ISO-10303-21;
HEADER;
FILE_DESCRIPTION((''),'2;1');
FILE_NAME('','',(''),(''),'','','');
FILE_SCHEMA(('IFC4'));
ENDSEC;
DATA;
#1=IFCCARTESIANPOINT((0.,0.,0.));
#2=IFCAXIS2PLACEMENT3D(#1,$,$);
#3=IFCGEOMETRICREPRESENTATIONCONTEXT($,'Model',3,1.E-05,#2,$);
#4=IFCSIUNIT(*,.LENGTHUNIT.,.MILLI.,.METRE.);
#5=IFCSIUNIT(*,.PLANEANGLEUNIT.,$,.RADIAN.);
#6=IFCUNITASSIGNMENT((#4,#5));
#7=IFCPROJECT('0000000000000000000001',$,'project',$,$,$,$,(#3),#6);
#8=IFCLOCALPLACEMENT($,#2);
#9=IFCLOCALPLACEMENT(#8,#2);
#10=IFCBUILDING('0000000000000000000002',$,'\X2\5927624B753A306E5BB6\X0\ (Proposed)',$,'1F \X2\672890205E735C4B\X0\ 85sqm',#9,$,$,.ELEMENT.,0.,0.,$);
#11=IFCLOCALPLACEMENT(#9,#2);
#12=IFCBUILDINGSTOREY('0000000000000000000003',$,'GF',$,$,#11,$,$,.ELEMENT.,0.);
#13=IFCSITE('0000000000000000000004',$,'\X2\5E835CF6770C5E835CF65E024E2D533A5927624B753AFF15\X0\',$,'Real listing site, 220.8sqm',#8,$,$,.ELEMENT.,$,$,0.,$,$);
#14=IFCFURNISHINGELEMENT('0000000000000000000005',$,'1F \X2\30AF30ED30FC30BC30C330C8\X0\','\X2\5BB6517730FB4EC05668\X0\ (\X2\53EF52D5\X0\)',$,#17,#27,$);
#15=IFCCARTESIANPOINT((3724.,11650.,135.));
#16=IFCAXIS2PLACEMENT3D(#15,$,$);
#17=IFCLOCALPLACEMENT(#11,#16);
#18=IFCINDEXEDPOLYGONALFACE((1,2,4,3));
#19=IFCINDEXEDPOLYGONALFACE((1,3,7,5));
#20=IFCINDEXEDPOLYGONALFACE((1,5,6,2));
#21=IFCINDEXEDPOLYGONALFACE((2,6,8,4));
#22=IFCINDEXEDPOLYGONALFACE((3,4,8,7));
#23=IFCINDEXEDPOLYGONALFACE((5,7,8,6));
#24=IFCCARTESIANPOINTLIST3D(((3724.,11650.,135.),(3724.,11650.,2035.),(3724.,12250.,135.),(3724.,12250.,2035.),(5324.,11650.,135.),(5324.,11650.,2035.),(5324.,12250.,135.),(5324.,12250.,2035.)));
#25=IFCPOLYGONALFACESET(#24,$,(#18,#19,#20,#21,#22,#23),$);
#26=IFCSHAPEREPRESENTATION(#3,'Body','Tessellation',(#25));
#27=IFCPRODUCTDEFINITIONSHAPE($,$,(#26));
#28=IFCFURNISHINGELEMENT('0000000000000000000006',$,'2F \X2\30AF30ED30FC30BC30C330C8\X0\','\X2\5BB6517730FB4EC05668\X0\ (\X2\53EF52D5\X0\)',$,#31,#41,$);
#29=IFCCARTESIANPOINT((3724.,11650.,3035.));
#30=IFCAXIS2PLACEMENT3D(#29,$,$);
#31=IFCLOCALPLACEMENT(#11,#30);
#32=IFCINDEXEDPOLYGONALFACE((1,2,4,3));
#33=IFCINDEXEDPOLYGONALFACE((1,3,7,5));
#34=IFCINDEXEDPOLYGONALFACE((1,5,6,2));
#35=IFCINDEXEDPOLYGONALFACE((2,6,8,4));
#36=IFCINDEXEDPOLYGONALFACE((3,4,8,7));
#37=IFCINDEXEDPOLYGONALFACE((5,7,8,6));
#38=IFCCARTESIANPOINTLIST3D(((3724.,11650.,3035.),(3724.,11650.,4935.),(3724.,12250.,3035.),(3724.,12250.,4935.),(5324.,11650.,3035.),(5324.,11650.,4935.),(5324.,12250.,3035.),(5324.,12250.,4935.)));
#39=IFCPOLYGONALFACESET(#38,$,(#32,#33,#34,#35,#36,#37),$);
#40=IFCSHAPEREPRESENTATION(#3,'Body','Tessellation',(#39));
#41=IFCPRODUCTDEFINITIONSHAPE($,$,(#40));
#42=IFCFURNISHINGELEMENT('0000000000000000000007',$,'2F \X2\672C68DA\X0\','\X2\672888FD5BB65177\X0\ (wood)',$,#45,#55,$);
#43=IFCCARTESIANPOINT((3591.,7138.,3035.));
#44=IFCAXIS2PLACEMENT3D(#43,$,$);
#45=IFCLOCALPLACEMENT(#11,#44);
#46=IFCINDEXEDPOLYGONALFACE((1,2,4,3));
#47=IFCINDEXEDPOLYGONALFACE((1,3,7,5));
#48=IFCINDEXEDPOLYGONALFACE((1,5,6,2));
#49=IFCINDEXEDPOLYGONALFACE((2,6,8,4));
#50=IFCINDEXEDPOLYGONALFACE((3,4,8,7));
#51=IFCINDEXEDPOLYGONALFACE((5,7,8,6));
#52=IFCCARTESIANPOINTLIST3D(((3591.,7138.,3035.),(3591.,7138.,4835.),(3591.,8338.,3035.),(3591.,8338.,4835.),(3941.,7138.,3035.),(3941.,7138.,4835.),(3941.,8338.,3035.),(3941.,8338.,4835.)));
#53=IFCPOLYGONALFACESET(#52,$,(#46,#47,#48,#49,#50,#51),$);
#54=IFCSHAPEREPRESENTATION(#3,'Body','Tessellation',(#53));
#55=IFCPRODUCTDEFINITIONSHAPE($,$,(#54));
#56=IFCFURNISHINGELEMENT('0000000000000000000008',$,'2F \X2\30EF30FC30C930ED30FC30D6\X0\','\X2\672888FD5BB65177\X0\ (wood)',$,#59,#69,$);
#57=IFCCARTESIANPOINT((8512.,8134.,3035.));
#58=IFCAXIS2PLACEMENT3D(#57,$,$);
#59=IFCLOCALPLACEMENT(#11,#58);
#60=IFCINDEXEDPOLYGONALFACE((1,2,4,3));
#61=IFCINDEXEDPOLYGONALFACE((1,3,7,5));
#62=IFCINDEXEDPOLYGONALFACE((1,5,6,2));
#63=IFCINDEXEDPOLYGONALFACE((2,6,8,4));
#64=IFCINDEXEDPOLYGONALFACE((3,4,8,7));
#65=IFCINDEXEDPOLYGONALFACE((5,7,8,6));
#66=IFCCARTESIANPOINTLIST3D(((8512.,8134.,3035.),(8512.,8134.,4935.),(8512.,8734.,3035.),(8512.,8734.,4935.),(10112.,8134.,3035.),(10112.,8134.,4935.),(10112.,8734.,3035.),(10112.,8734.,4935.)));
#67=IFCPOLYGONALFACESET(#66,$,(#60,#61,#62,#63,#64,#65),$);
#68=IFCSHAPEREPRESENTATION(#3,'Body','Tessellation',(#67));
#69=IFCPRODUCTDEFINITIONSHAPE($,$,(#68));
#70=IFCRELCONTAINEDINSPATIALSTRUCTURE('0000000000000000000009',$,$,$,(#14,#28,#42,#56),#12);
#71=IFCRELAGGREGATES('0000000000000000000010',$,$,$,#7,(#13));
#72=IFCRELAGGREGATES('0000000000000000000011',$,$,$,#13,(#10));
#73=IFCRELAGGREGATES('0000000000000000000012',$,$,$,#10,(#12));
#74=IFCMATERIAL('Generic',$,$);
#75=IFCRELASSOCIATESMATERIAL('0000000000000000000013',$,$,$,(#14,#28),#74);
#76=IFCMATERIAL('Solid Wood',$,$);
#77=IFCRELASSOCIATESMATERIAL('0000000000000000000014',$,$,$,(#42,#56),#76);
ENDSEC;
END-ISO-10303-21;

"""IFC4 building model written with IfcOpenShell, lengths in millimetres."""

from ifc_helpers import new_model, si_unit, frame, frame_2d, origin, place, context, project, spatial, rectangle, extrude, material, element, save


model = new_model("IFC4")

# Units and contexts
model_context = context("Model", 3, precision=1e-05, world=origin())
ifc_project = project(units=[si_unit("LENGTHUNIT", "METRE", prefix="MILLI"), si_unit("PLANEANGLEUNIT", "RADIAN")], contexts=[model_context])

# Site, building, storey
site_placement = place(None, origin())
site = spatial("IfcSite", under=ifc_project, at=site_placement, Name="広島県広島市中区大手町５", ObjectType="Real listing site, 220.8sqm", CompositionType="ELEMENT", RefElevation=0.0)
building_placement = place(site_placement, origin())
building = spatial("IfcBuilding", under=site, at=building_placement, Name="大手町の家 (Proposed)", ObjectType="1F 木造平屋 85sqm", CompositionType="ELEMENT", ElevationOfRefHeight=0.0, ElevationOfTerrain=0.0)
storey_placement = place(building_placement, origin())
storey = spatial("IfcBuildingStorey", under=building, at=storey_placement, Name="GF", CompositionType="ELEMENT", Elevation=0.0)

# Shared definitions
ifc_material_1 = material(Name="Solid Wood")

# Shared definitions
ifc_material_2 = material(Name="Generic")

# Furnishing elements
furnishing_1_placement = place(storey_placement, frame((3724.0, 11650.0, 135.0)))
element("IfcFurnishingElement", 1, at=furnishing_1_placement, inside=storey, material=ifc_material_2, Name="1F クローゼット", Description="家具・什器 (可動)", context=model_context, shape_type="SweptSolid", body=[
    extrude(rectangle(XDim=1600.0, YDim=600.0, at=frame_2d((800.0, 300.0))), frame((3724.0, 11650.0, 135.0)), (0.0, 0.0, 1.0), 1900.0),
])
furnishing_2_placement = place(storey_placement, frame((3724.0, 11650.0, 3035.0)))
element("IfcFurnishingElement", 2, at=furnishing_2_placement, inside=storey, material=ifc_material_2, Name="2F クローゼット", Description="家具・什器 (可動)", context=model_context, shape_type="SweptSolid", body=[
    extrude(rectangle(XDim=1600.0, YDim=600.0, at=frame_2d((800.0, 300.0))), frame((3724.0, 11650.0, 3035.0)), (0.0, 0.0, 1.0), 1900.0),
])
furnishing_3_placement = place(storey_placement, frame((3591.0, 7138.0, 3035.0)))
element("IfcFurnishingElement", 3, at=furnishing_3_placement, inside=storey, material=ifc_material_1, Name="2F 本棚", Description="木製家具 (wood)", context=model_context, shape_type="SweptSolid", body=[
    extrude(rectangle(XDim=350.0, YDim=1200.0, at=frame_2d((175.0, 600.0))), frame((3591.0, 7138.0, 3035.0)), (0.0, 0.0, 1.0), 1800.0),
])
furnishing_4_placement = place(storey_placement, frame((8512.0, 8134.0, 3035.0)))
element("IfcFurnishingElement", 4, at=furnishing_4_placement, inside=storey, material=ifc_material_1, Name="2F ワードローブ", Description="木製家具 (wood)", context=model_context, shape_type="SweptSolid", body=[
    extrude(rectangle(XDim=1600.0, YDim=600.0, at=frame_2d((800.0, 300.0))), frame((8512.0, 8134.0, 3035.0)), (0.0, 0.0, 1.0), 1900.0),
])

save(model, "model.ifc")
